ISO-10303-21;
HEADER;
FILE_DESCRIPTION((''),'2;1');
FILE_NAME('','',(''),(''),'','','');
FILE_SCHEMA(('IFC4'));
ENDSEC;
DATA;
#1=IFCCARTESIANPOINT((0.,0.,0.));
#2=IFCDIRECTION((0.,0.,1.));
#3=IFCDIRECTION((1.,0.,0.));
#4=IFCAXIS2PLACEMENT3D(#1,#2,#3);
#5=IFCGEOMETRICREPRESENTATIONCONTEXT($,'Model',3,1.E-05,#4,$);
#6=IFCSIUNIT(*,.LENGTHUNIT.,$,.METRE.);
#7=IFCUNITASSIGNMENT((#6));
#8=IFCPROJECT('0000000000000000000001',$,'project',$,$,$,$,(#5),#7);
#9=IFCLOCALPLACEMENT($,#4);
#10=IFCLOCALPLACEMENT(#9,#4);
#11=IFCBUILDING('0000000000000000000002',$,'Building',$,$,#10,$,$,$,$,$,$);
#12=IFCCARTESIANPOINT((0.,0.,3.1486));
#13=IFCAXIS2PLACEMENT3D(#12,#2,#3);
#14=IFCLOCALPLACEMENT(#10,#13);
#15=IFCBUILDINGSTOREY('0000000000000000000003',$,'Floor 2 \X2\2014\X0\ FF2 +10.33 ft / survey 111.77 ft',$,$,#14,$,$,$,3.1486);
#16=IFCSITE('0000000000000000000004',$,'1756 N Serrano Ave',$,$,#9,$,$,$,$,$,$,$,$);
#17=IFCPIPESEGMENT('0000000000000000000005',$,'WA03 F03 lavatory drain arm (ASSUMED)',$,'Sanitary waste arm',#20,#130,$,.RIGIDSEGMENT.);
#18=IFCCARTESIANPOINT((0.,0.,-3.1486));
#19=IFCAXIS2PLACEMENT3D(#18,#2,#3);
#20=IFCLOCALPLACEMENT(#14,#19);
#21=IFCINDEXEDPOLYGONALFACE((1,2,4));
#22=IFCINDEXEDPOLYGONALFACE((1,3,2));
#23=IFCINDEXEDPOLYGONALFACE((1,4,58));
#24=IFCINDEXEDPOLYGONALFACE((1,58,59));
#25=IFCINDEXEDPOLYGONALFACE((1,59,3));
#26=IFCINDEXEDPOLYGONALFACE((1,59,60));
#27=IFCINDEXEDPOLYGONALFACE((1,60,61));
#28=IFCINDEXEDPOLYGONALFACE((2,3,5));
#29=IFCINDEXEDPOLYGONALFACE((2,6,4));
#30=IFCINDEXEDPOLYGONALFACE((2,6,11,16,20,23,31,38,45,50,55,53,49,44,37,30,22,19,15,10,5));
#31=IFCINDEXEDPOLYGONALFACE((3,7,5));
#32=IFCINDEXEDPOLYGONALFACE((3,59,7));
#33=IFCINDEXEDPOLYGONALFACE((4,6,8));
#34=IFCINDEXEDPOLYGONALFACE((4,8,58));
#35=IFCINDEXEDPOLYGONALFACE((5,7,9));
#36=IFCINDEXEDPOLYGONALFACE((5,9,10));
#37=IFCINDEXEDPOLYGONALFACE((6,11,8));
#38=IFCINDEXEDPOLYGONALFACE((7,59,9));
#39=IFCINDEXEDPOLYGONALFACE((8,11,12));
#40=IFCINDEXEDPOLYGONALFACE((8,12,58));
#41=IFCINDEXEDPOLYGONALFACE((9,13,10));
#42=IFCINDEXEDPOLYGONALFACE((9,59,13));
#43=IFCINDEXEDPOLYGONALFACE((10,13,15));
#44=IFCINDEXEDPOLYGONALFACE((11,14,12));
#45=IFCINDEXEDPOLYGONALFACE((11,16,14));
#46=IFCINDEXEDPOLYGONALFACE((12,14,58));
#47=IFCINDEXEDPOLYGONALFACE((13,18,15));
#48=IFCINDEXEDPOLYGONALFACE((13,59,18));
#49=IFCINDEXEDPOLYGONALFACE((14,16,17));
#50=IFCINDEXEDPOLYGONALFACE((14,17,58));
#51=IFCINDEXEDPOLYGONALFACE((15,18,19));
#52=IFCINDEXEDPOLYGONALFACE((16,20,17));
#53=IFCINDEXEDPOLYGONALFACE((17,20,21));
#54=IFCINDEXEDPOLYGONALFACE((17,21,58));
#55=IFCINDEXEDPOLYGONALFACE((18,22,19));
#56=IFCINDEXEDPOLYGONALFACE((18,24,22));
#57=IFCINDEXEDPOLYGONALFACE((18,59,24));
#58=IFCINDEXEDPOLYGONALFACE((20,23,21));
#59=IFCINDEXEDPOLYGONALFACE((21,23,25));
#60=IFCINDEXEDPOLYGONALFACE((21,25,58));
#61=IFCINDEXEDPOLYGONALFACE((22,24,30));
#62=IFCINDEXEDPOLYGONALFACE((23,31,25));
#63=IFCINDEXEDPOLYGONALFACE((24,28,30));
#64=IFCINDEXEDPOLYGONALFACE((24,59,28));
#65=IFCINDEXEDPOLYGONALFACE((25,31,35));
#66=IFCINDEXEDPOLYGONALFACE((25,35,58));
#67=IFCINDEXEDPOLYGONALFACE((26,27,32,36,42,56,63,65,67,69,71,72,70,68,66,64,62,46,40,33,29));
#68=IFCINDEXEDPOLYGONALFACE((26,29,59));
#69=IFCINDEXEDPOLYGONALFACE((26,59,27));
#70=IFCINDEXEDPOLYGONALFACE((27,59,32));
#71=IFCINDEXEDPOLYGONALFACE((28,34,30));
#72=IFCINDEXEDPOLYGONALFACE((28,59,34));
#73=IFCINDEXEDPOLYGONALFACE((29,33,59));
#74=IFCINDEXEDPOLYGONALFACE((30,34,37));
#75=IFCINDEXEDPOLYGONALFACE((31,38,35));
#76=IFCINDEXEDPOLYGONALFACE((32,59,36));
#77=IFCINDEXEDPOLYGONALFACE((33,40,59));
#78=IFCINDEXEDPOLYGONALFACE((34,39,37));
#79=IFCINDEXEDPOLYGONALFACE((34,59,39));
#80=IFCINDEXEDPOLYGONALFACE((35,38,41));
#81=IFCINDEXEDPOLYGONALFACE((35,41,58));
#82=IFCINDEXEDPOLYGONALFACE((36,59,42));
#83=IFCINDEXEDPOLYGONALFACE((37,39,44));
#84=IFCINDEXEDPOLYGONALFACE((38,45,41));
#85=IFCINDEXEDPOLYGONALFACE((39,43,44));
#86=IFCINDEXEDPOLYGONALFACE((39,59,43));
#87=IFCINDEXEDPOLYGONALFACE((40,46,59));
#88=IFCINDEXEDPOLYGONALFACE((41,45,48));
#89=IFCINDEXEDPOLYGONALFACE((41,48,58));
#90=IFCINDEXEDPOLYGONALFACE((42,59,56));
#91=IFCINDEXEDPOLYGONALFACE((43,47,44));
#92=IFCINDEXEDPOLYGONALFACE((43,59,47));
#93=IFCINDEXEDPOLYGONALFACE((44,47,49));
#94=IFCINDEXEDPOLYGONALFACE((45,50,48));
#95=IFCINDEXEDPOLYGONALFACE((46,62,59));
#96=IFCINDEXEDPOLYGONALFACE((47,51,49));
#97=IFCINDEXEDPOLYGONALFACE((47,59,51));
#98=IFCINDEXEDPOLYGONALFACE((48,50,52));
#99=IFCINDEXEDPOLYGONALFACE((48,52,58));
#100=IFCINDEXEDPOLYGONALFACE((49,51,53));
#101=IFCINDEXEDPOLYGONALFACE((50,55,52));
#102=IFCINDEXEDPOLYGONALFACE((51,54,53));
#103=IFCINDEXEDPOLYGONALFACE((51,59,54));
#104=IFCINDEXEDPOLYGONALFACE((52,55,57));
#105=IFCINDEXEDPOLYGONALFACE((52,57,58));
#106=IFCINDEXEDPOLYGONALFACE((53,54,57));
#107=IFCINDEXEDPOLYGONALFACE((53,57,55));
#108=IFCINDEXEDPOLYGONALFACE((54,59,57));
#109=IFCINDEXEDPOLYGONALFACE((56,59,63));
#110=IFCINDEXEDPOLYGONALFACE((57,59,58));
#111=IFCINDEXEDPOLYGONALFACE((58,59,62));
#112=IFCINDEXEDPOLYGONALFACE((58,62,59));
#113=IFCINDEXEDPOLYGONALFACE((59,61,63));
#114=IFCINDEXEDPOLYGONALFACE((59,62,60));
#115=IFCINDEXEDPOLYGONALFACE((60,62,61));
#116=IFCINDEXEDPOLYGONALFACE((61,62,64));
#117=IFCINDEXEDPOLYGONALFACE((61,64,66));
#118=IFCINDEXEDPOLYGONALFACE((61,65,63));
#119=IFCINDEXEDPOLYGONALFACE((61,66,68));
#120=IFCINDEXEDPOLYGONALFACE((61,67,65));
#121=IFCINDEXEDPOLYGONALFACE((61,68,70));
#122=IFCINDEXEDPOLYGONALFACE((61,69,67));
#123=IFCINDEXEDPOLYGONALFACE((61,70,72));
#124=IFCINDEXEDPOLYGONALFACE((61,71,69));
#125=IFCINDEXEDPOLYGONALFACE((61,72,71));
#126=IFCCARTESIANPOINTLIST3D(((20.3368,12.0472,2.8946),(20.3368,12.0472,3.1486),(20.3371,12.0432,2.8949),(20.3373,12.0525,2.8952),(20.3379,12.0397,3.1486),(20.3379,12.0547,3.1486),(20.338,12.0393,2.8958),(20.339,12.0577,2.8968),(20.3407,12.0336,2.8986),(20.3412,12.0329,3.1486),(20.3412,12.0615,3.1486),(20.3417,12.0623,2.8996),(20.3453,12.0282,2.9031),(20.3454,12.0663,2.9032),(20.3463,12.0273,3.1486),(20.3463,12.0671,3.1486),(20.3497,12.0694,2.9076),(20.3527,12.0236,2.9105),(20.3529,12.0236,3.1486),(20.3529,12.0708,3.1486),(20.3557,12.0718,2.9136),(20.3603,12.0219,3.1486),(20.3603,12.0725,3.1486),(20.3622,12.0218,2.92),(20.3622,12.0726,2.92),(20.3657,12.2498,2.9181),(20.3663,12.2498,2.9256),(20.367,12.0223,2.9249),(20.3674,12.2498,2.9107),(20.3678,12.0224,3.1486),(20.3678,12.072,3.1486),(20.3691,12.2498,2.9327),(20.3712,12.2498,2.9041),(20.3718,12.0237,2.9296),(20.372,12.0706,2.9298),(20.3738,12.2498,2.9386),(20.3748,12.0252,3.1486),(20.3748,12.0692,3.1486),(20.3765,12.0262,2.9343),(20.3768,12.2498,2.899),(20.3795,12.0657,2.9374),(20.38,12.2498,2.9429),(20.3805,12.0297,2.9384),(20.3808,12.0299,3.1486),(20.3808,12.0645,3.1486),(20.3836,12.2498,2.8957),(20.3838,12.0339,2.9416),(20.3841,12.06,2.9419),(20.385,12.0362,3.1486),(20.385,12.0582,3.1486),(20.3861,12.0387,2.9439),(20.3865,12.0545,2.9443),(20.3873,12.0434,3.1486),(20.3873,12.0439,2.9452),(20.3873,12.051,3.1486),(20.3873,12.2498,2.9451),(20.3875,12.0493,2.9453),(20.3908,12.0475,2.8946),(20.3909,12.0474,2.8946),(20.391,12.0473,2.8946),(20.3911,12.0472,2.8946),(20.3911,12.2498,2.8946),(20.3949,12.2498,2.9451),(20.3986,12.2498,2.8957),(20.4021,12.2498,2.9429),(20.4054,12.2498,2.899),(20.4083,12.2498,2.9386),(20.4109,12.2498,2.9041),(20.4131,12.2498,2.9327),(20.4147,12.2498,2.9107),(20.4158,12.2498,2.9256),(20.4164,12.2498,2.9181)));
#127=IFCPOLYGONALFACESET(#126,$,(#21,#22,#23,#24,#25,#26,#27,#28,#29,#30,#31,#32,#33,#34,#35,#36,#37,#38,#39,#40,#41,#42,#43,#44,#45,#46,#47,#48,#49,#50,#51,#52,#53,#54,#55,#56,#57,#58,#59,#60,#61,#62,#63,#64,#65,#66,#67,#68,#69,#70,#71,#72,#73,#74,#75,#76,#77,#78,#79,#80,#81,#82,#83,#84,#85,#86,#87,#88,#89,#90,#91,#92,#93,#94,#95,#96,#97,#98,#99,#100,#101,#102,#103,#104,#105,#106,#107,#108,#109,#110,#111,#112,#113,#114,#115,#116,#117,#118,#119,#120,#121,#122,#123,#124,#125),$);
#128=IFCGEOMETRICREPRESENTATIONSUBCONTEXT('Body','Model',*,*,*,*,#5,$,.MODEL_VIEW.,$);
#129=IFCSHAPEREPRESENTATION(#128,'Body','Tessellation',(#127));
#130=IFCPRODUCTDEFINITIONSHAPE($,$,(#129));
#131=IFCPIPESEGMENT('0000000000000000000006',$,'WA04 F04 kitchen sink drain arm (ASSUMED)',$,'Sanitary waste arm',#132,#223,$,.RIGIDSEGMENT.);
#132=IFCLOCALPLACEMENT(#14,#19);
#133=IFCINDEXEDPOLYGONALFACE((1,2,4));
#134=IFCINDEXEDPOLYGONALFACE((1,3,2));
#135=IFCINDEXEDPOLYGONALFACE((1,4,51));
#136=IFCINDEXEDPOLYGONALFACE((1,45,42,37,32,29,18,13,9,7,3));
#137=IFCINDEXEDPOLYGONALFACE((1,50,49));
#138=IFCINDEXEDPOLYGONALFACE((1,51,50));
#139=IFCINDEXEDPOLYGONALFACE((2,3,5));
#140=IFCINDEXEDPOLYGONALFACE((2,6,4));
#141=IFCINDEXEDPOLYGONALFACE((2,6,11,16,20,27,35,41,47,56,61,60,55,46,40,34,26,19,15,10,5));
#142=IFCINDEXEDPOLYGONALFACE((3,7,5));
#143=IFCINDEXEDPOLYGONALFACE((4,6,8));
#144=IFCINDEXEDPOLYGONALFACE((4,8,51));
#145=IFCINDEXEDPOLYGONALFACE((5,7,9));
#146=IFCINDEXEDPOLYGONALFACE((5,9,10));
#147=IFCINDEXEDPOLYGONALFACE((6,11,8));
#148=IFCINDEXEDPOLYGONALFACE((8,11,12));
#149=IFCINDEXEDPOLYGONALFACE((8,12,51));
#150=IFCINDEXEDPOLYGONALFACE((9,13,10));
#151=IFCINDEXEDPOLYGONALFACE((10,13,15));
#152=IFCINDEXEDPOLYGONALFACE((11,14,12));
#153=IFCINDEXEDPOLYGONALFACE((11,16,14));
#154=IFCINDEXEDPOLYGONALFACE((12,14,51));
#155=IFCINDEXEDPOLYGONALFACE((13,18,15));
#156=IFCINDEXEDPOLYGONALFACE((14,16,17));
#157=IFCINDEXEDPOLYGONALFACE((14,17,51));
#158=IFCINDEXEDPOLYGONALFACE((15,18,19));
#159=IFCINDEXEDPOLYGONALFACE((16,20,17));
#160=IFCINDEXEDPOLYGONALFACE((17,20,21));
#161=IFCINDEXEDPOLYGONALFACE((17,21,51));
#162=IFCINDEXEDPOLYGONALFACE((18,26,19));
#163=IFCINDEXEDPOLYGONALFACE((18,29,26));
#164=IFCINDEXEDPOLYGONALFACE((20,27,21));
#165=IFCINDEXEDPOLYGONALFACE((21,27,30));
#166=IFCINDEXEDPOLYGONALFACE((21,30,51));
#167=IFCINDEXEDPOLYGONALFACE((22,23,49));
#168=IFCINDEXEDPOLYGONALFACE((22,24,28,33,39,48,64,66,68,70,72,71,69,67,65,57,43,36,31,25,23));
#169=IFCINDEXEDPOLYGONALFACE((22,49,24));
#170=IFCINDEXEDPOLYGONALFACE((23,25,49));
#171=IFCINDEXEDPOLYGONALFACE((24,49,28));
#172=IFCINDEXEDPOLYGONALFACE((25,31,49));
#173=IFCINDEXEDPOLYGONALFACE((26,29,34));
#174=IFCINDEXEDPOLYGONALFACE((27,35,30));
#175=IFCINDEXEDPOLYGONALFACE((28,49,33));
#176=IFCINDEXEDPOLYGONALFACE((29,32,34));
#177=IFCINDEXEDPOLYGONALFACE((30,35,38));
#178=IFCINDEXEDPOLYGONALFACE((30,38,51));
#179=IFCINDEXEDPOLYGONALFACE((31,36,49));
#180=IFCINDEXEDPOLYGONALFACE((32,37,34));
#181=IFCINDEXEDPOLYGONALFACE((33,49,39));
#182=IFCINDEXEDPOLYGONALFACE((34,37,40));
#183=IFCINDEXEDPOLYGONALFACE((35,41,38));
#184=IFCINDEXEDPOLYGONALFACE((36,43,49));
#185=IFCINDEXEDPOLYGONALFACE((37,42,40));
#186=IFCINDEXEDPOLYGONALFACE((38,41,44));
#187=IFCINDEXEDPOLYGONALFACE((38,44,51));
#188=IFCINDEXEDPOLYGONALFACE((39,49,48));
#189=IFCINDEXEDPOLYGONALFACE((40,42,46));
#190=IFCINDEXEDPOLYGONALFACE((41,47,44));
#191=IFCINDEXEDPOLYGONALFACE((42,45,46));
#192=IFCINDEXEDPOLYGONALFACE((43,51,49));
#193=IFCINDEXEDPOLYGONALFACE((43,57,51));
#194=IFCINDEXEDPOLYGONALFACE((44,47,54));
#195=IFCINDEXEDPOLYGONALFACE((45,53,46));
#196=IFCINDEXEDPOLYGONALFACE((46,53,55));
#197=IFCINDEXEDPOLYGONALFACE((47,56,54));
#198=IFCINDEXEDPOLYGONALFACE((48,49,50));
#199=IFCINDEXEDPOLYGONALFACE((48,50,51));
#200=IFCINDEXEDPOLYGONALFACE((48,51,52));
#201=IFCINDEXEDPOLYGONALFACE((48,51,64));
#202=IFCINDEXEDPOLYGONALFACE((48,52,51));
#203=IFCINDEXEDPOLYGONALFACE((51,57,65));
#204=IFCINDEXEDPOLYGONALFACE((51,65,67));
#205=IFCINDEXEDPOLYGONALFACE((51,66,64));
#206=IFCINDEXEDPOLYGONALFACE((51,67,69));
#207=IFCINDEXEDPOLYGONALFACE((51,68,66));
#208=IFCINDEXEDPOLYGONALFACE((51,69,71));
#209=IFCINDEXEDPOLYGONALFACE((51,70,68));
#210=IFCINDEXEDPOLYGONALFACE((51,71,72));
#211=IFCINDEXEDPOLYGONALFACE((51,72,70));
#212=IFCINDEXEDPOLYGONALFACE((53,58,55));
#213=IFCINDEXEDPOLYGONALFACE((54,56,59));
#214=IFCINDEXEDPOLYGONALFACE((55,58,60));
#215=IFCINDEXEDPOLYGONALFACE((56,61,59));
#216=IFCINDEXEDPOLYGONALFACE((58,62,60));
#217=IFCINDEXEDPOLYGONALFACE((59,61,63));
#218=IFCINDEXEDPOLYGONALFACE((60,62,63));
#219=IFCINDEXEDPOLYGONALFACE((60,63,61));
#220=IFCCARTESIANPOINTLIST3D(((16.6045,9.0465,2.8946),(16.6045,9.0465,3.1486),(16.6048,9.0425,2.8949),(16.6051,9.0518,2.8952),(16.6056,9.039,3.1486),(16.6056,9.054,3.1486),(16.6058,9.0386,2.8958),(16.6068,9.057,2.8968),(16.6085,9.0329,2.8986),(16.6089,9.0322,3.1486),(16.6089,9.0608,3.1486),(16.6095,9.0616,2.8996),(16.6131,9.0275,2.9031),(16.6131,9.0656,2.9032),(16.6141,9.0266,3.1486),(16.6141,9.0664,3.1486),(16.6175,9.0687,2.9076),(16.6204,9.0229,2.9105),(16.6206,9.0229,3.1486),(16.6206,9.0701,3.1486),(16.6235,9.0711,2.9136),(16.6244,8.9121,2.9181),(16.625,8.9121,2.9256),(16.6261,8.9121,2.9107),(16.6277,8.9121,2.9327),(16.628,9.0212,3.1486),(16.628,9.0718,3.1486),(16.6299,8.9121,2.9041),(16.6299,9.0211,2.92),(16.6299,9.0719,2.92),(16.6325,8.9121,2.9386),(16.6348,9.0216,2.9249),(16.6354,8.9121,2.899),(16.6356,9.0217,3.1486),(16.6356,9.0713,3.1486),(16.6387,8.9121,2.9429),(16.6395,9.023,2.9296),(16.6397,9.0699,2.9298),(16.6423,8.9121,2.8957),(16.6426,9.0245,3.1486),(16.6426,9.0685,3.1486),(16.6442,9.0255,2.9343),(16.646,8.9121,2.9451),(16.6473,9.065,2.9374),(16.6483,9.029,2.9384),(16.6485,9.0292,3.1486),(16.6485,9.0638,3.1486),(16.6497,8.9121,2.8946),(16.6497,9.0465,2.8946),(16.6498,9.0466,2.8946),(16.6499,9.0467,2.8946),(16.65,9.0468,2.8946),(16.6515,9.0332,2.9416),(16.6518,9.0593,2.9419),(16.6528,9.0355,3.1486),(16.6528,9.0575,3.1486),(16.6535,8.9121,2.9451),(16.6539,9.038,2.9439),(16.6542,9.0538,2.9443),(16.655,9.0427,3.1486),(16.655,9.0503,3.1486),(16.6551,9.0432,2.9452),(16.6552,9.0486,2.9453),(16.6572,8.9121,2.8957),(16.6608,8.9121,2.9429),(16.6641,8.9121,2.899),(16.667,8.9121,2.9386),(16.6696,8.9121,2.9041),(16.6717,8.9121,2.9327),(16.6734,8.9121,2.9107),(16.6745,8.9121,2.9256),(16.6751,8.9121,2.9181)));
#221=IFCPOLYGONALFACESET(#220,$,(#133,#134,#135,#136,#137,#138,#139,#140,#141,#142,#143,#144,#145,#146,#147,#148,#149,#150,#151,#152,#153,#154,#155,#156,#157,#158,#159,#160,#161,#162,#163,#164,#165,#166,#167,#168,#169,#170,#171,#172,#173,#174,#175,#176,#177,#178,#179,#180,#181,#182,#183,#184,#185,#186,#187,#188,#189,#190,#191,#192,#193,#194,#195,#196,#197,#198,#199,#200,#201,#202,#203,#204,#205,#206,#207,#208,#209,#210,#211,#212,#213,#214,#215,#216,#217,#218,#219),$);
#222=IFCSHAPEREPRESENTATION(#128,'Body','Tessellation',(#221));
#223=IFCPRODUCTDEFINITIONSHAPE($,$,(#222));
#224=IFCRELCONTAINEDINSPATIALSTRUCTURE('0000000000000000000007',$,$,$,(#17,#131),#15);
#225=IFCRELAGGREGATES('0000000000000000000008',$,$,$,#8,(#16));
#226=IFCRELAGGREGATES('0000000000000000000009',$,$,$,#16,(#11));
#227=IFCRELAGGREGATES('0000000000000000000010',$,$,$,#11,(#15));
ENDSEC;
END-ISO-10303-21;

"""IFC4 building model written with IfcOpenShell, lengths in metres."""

from ifc_helpers import new_model, entity, si_unit, frame, origin_with_axes, place, context, subcontext, project, spatial, element, save


model = new_model("IFC4")

# Units and contexts
model_context = context("Model", 3, precision=1e-05, world=origin_with_axes())
body_context = subcontext(model_context, "Body", "Model", "MODEL_VIEW")
ifc_project = project(units=[si_unit("LENGTHUNIT", "METRE")], contexts=[model_context])

# Site, building, storey
site_placement = place(None, origin_with_axes())
site = spatial("IfcSite", under=ifc_project, at=site_placement, Name="1756 N Serrano Ave")
building_placement = place(site_placement, origin_with_axes())
building = spatial("IfcBuilding", under=site, at=building_placement, Name="Building")
storey_placement = place(building_placement, frame((0.0, 0.0, 3.1486), z_axis=(0.0, 0.0, 1.0), x_axis=(1.0, 0.0, 0.0)))
storey = spatial("IfcBuildingStorey", under=building, at=storey_placement, Name="Floor 2 — FF2 +10.33 ft / survey 111.77 ft", Elevation=3.1486)

# Pipe segments
pipe_segment_1_placement = place(storey_placement, frame((0.0, 0.0, -3.1486), z_axis=(0.0, 0.0, 1.0), x_axis=(1.0, 0.0, 0.0)))
element("IfcPipeSegment", 1, at=pipe_segment_1_placement, inside=storey, Name="WA03 F03 lavatory drain arm (ASSUMED)", ObjectType="Sanitary waste arm", PredefinedType="RIGIDSEGMENT", context=body_context, shape_type="AdvancedSweptSolid", body=[
    entity("IfcSweptDiskSolid", entity("IfcPolyline", [entity("IfcCartesianPoint", [20.3621, 12.0472, 3.1486]), entity("IfcCartesianPoint", [20.3621, 12.0472, 2.92]), entity("IfcCartesianPoint", [20.3911, 12.0472, 2.92]), entity("IfcCartesianPoint", [20.3911, 12.2498, 2.92])]), 0.0254),
])
pipe_segment_2_placement = place(storey_placement, frame((0.0, 0.0, -3.1486), z_axis=(0.0, 0.0, 1.0), x_axis=(1.0, 0.0, 0.0)))
element("IfcPipeSegment", 2, at=pipe_segment_2_placement, inside=storey, Name="WA04 F04 kitchen sink drain arm (ASSUMED)", ObjectType="Sanitary waste arm", PredefinedType="RIGIDSEGMENT", context=body_context, shape_type="AdvancedSweptSolid", body=[
    entity("IfcSweptDiskSolid", entity("IfcPolyline", [entity("IfcCartesianPoint", [16.6299, 9.0465, 3.1486]), entity("IfcCartesianPoint", [16.6299, 9.0465, 2.92]), entity("IfcCartesianPoint", [16.6497, 9.0465, 2.92]), entity("IfcCartesianPoint", [16.6497, 8.9121, 2.92])]), 0.0254),
])

save(model, "model.ifc")
